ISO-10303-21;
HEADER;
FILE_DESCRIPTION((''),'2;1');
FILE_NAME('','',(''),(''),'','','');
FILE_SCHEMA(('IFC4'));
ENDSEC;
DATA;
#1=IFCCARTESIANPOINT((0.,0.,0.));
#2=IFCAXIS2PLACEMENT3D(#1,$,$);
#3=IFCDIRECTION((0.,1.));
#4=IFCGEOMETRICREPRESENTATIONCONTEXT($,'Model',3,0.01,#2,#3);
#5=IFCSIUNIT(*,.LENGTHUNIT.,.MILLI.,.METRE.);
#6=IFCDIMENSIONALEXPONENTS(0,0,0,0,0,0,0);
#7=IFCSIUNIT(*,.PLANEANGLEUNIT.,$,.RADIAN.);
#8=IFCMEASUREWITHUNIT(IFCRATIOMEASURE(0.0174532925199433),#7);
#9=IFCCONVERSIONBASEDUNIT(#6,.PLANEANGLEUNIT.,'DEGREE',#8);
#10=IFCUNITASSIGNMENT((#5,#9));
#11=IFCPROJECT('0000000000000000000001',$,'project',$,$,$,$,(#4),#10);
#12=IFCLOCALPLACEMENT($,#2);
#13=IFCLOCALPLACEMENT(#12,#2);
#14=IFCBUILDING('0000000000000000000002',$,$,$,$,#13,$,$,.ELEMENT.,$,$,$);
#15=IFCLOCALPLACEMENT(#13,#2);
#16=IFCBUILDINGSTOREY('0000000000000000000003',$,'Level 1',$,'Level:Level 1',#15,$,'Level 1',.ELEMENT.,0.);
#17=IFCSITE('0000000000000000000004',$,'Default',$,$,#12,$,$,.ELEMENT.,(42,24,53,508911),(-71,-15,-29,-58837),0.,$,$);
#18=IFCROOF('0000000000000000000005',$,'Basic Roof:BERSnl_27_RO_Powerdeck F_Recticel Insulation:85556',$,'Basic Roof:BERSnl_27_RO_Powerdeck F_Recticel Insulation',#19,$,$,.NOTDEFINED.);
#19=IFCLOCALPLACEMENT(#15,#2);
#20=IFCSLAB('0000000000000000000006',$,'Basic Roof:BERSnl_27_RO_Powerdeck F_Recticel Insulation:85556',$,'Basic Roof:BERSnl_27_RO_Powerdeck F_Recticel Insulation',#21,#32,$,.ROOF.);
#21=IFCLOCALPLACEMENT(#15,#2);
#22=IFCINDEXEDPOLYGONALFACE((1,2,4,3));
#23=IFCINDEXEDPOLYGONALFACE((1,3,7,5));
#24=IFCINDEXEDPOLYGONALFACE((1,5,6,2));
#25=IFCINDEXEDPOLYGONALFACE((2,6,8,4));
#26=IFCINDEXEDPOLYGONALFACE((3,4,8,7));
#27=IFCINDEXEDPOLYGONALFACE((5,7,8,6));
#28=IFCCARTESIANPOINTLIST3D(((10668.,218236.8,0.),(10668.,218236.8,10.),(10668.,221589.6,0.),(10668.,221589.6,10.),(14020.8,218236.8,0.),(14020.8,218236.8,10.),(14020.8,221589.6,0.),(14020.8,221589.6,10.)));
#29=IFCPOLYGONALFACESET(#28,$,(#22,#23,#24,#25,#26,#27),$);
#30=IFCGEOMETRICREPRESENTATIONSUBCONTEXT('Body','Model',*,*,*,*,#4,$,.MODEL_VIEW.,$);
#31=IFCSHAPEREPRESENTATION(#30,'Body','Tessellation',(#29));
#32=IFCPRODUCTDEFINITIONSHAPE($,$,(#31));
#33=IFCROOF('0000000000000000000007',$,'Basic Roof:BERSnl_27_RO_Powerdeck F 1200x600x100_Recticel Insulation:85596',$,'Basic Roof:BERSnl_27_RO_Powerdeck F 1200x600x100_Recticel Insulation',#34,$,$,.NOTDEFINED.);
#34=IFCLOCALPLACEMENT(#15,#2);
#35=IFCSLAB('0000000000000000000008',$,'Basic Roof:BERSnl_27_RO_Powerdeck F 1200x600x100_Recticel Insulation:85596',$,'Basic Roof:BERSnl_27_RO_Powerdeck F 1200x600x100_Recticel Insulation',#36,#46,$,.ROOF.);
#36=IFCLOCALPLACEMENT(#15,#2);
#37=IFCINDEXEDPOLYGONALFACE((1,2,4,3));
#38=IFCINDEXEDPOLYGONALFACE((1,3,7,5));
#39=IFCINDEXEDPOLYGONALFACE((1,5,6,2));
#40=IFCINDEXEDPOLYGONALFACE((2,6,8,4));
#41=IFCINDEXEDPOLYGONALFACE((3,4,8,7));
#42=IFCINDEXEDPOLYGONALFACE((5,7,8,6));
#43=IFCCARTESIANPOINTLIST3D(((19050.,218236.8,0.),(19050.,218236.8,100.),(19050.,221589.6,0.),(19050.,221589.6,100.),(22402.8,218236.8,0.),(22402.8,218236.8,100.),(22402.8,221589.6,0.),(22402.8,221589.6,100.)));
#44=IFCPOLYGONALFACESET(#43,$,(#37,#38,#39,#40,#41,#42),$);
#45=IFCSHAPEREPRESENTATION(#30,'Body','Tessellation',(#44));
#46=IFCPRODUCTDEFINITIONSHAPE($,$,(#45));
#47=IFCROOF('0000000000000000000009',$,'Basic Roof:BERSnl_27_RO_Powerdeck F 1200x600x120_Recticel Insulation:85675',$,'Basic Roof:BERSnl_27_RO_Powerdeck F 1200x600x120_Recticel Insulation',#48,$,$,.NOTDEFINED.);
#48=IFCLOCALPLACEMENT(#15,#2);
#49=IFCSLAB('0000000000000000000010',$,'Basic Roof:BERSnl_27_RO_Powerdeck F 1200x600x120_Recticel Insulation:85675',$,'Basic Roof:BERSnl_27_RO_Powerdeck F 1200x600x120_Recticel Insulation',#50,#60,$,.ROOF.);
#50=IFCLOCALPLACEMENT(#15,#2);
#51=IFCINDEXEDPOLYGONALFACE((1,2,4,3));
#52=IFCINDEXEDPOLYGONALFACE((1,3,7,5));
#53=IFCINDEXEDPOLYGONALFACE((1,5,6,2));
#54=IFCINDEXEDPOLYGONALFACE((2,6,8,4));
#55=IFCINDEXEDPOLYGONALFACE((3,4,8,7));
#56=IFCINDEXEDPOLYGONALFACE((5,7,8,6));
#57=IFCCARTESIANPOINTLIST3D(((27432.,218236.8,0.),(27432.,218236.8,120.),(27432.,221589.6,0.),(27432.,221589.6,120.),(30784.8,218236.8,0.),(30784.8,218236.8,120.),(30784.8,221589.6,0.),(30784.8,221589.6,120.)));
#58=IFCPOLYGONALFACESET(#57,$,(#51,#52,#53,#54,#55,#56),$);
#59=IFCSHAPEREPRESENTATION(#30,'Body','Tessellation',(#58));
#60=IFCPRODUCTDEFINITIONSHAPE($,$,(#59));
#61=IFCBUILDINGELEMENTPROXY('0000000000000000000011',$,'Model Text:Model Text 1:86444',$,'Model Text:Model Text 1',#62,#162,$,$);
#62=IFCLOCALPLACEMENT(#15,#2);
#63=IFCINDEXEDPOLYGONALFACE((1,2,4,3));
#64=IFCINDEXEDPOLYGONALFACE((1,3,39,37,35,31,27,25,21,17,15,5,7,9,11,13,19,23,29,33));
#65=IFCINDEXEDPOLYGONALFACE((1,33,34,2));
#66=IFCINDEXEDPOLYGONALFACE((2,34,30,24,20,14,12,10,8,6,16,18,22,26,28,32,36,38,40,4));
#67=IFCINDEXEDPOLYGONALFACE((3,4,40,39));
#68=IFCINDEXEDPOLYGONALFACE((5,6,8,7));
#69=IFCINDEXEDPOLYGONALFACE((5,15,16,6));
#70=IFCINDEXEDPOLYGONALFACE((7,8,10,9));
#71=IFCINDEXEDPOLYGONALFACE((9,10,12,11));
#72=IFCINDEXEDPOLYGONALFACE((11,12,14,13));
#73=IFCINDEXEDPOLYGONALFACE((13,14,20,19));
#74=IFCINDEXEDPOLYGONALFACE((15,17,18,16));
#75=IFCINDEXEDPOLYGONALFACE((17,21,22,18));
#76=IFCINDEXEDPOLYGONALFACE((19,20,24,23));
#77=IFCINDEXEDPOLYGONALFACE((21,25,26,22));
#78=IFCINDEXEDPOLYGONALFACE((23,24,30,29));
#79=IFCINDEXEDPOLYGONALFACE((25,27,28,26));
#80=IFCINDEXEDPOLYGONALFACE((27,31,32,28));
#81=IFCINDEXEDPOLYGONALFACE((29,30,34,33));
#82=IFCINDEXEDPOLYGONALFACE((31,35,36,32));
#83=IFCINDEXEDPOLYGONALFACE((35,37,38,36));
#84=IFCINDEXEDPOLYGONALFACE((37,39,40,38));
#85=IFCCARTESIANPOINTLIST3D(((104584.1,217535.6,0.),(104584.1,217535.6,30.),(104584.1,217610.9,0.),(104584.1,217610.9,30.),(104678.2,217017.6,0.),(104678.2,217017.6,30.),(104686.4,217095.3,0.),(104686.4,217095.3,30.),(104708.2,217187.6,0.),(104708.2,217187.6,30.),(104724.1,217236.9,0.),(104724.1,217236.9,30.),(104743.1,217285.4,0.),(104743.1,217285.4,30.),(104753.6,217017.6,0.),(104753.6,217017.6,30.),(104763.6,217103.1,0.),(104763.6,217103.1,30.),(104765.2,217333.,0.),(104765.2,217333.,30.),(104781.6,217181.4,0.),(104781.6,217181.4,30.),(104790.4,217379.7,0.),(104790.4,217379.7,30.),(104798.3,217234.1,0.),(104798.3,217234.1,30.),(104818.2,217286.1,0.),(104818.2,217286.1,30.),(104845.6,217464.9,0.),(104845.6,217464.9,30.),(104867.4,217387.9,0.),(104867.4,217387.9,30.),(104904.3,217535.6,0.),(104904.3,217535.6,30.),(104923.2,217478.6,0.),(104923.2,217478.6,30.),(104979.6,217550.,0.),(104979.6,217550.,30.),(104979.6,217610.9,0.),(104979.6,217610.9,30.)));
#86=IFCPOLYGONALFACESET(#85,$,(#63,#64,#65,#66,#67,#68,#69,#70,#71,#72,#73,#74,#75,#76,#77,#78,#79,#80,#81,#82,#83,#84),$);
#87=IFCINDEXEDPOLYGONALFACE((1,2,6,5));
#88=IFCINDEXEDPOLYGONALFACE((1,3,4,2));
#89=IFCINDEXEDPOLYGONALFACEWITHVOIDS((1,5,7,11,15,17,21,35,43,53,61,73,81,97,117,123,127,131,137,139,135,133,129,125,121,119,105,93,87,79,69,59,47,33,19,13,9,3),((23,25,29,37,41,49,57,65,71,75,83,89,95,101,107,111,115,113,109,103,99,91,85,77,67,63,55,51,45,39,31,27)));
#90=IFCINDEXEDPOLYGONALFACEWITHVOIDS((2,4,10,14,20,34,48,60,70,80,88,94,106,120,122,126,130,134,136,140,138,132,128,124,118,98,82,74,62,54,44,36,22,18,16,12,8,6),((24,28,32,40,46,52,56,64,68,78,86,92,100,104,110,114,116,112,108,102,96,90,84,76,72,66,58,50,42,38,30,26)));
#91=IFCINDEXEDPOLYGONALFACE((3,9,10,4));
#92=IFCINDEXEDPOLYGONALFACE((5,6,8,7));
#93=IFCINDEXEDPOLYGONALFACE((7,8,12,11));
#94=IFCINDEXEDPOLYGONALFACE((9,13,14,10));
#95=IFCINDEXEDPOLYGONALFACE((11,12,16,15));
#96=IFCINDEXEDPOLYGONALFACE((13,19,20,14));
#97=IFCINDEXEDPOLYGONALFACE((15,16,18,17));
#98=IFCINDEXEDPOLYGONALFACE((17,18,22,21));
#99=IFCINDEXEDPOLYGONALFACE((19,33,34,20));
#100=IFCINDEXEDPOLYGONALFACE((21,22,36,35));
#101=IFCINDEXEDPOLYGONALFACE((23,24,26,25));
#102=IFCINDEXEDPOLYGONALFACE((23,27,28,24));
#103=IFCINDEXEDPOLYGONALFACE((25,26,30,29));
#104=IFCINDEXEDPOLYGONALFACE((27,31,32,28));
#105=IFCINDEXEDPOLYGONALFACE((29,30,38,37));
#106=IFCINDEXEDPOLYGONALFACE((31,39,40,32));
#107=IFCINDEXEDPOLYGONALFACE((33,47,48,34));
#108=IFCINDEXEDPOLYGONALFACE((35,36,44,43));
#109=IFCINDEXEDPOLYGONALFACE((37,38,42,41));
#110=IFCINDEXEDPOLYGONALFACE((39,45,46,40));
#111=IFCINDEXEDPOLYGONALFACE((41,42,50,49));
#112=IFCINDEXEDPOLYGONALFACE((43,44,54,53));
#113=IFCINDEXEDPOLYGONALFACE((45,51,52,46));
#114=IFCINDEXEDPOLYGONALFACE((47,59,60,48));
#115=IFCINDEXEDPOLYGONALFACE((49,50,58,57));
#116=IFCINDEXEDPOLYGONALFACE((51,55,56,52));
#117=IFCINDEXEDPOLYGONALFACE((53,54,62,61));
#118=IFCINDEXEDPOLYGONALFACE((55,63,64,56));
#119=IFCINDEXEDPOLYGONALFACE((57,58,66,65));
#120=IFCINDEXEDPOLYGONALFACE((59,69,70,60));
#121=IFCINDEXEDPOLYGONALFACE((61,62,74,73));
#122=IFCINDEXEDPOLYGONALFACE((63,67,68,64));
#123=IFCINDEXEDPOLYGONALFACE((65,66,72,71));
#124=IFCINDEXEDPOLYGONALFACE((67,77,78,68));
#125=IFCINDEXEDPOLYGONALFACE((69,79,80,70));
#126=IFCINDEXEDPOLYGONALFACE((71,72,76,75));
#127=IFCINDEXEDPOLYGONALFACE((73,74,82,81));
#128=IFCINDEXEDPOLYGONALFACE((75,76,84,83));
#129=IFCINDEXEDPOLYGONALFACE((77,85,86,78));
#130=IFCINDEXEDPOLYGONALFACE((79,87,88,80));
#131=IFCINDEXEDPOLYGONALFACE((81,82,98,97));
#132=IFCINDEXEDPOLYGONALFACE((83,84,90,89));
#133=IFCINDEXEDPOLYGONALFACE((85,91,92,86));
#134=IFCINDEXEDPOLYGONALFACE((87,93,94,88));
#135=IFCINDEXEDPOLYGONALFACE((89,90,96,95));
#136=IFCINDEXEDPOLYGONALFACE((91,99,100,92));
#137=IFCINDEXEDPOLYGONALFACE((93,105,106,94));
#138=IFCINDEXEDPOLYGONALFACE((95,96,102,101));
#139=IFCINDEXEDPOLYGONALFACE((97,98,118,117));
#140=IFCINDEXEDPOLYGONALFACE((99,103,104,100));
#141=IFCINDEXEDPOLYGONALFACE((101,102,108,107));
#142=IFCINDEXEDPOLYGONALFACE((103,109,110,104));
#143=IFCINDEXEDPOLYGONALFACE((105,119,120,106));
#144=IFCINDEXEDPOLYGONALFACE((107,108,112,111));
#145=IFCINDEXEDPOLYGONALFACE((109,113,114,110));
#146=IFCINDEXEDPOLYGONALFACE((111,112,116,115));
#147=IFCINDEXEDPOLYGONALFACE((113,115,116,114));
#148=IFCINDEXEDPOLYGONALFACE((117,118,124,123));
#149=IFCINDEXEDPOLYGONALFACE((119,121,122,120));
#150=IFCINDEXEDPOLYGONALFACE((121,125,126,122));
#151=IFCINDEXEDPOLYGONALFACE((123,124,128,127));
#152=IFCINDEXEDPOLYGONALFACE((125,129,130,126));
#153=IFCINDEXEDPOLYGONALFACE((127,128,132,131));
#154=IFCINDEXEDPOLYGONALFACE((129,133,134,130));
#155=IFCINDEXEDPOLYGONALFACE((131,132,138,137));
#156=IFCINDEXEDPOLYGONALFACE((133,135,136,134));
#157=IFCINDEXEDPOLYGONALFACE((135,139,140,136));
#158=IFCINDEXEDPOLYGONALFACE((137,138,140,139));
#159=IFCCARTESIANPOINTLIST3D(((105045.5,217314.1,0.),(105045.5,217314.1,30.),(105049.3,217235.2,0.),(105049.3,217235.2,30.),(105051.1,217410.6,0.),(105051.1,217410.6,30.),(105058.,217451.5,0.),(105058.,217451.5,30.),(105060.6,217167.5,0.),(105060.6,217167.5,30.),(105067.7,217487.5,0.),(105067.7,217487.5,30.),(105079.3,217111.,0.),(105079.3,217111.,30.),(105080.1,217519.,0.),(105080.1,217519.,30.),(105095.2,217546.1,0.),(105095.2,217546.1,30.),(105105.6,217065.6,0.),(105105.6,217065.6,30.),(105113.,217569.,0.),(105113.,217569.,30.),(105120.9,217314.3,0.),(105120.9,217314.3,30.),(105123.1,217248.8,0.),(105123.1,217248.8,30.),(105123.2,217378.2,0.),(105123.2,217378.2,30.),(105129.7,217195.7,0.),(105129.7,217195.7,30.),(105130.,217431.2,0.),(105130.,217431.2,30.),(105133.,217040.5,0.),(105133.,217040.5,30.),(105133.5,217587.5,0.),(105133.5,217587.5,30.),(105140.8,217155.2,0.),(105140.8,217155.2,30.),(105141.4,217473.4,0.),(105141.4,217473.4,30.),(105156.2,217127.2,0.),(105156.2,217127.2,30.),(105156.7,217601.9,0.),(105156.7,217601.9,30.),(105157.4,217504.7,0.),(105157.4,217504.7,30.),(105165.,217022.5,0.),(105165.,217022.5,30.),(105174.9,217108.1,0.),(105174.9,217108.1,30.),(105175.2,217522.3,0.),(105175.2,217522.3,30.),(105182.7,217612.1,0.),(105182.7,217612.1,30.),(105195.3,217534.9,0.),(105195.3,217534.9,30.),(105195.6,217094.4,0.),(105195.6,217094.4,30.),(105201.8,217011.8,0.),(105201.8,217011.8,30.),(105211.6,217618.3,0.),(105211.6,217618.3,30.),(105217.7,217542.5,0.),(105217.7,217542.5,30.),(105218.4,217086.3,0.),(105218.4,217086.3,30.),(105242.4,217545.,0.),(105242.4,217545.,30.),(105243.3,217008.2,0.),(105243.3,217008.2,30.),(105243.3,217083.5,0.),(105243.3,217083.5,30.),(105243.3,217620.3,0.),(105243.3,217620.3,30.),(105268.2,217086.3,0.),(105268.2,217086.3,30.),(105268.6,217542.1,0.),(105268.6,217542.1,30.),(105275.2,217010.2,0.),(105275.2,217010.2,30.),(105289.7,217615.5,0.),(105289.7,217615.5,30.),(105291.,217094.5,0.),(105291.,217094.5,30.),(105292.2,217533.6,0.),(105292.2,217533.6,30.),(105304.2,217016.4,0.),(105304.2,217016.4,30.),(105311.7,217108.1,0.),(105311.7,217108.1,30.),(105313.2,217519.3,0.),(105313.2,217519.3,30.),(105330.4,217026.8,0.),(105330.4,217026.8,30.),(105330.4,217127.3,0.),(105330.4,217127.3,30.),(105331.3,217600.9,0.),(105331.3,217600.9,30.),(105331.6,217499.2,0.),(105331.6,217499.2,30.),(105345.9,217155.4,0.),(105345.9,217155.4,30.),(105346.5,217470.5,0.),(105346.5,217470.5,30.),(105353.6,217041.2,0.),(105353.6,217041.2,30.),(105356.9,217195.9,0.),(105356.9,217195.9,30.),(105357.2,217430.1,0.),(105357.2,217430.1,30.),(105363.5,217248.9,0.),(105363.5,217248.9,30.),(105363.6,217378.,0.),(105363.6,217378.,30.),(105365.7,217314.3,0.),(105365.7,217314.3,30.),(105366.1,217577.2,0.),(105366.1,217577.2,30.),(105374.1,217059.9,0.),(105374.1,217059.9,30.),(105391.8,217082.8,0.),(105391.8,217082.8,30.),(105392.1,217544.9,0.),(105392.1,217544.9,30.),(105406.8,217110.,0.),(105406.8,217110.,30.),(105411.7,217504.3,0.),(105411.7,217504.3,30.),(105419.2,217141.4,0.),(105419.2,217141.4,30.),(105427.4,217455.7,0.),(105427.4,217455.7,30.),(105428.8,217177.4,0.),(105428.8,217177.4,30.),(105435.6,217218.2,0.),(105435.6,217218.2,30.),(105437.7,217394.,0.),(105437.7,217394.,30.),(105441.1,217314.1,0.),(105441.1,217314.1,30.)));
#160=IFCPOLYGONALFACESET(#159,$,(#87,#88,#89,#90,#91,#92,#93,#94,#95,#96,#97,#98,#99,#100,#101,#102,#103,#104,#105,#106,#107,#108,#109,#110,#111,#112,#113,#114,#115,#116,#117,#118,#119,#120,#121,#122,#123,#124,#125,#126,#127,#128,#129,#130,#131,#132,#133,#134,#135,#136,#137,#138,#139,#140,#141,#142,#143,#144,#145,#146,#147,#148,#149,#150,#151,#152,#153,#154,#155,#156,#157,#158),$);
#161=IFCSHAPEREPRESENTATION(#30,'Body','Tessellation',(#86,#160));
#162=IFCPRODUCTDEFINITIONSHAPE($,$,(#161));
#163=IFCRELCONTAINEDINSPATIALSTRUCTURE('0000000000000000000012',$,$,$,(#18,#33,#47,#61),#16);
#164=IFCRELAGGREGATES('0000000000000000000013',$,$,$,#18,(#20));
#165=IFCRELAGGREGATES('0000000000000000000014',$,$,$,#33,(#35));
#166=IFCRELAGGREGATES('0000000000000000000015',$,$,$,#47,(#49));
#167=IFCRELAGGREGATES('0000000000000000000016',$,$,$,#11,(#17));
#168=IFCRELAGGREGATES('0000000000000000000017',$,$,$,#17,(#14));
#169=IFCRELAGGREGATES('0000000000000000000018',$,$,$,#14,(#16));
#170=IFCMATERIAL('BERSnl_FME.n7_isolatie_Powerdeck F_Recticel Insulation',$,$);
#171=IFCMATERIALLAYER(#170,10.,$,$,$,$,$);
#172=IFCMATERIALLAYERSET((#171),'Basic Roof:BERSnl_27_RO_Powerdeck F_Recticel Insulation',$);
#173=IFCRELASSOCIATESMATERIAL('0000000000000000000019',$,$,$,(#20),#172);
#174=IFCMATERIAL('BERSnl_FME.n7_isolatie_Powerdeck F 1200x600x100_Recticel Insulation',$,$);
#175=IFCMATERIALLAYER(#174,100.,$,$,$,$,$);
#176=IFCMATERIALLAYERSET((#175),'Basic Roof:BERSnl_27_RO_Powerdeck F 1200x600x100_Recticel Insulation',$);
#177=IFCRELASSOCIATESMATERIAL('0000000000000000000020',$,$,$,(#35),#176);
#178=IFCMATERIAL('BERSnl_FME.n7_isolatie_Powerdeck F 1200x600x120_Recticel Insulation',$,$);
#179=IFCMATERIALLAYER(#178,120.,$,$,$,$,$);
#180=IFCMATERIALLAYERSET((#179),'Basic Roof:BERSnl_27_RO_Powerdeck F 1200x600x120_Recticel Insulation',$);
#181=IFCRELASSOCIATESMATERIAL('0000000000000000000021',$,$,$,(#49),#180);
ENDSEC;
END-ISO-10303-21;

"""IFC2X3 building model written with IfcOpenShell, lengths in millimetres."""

from ifc_helpers import new_model, entity, si_unit, converted_unit, direction, frame, frame_2d, origin, place, context, subcontext, project, spatial, polyline, rectangle, outline, extrude, material, layer, layer_set, element, aggregate, save


model = new_model("IFC2X3")

# Units and contexts
model_context = context("Model", 3, precision=0.01, world=origin(), true_north=direction((0.0, 1.0)))
body_context = subcontext(model_context, "Body", "Model", "MODEL_VIEW")
ifc_project = project(units=[si_unit("LENGTHUNIT", "METRE", prefix="MILLI"), converted_unit("PLANEANGLEUNIT", "DEGREE", entity("IfcRatioMeasure", 0.0174532925199433), si_unit("PLANEANGLEUNIT", "RADIAN"), dimensions=[0, 0, 0, 0, 0, 0, 0])], contexts=[model_context])

# Site, building, storey
site_placement = place(None, origin())
site = spatial("IfcSite", under=ifc_project, at=site_placement, Name="Default", CompositionType="ELEMENT", RefLatitude=(42, 24, 53, 508911), RefLongitude=(-71, -15, -29, -58837), RefElevation=0.0)
building_placement = place(site_placement, origin())
building = spatial("IfcBuilding", under=site, at=building_placement, CompositionType="ELEMENT")
storey_placement = place(building_placement, origin())
storey = spatial("IfcBuildingStorey", under=building, at=storey_placement, Name="Level 1", ObjectType="Level:Level 1", LongName="Level 1", CompositionType="ELEMENT", Elevation=0.0)

# Roofs, slabs
roof_1_placement = place(storey_placement, frame((10668.0, 218236.8, 0.0)))
roof_1 = element("IfcRoof", 1, at=roof_1_placement, inside=storey, Name="Basic Roof:BERSnl_27_RO_Powerdeck F_Recticel Insulation:85556", ObjectType="Basic Roof:BERSnl_27_RO_Powerdeck F_Recticel Insulation", ShapeType="NOTDEFINED")
ifc_material_1 = material(Name="BERSnl_FME.n7_isolatie_Powerdeck F_Recticel Insulation")
ifc_layer_1 = layer(ifc_material_1, 10.0)
ifc_layer_set_1 = layer_set([ifc_layer_1], Name="Basic Roof:BERSnl_27_RO_Powerdeck F_Recticel Insulation")
slab_1_placement = place(roof_1_placement, origin())
slab_1 = element("IfcSlab", 2, at=slab_1_placement, material=ifc_layer_set_1, Name="Basic Roof:BERSnl_27_RO_Powerdeck F_Recticel Insulation:85556", ObjectType="Basic Roof:BERSnl_27_RO_Powerdeck F_Recticel Insulation", PredefinedType="ROOF", context=body_context, shape_type="SweptSolid", body=[
    extrude(rectangle(XDim=3352.8, YDim=3352.8, at=frame_2d((0.0, 0.0), x_axis=(-1.0, 0.0))), frame((1676.4, 1676.4, 0.0)), (0.0, 0.0, 1.0), 10.0),
])
aggregate(roof_1, [slab_1])
roof_2_placement = place(storey_placement, frame((19050.0, 218236.8, 0.0)))
roof_2 = element("IfcRoof", 3, at=roof_2_placement, inside=storey, Name="Basic Roof:BERSnl_27_RO_Powerdeck F 1200x600x100_Recticel Insulation:85596", ObjectType="Basic Roof:BERSnl_27_RO_Powerdeck F 1200x600x100_Recticel Insulation", ShapeType="NOTDEFINED")
ifc_material_2 = material(Name="BERSnl_FME.n7_isolatie_Powerdeck F 1200x600x100_Recticel Insulation")
ifc_layer_2 = layer(ifc_material_2, 100.0)
ifc_layer_set_2 = layer_set([ifc_layer_2], Name="Basic Roof:BERSnl_27_RO_Powerdeck F 1200x600x100_Recticel Insulation")
slab_2_placement = place(roof_2_placement, origin())
slab_2 = element("IfcSlab", 4, at=slab_2_placement, material=ifc_layer_set_2, Name="Basic Roof:BERSnl_27_RO_Powerdeck F 1200x600x100_Recticel Insulation:85596", ObjectType="Basic Roof:BERSnl_27_RO_Powerdeck F 1200x600x100_Recticel Insulation", PredefinedType="ROOF", context=body_context, shape_type="SweptSolid", body=[
    extrude(rectangle(XDim=3352.8, YDim=3352.8, at=frame_2d((0.0, 0.0), x_axis=(-1.0, 0.0))), frame((1676.4, 1676.4, 0.0)), (0.0, 0.0, 1.0), 100.0),
])
aggregate(roof_2, [slab_2])
roof_3_placement = place(storey_placement, frame((27432.0, 218236.8, 0.0)))
roof_3 = element("IfcRoof", 5, at=roof_3_placement, inside=storey, Name="Basic Roof:BERSnl_27_RO_Powerdeck F 1200x600x120_Recticel Insulation:85675", ObjectType="Basic Roof:BERSnl_27_RO_Powerdeck F 1200x600x120_Recticel Insulation", ShapeType="NOTDEFINED")
ifc_material_3 = material(Name="BERSnl_FME.n7_isolatie_Powerdeck F 1200x600x120_Recticel Insulation")
ifc_layer_3 = layer(ifc_material_3, 120.0)
ifc_layer_set_3 = layer_set([ifc_layer_3], Name="Basic Roof:BERSnl_27_RO_Powerdeck F 1200x600x120_Recticel Insulation")
slab_3_placement = place(roof_3_placement, origin())
slab_3 = element("IfcSlab", 6, at=slab_3_placement, material=ifc_layer_set_3, Name="Basic Roof:BERSnl_27_RO_Powerdeck F 1200x600x120_Recticel Insulation:85675", ObjectType="Basic Roof:BERSnl_27_RO_Powerdeck F 1200x600x120_Recticel Insulation", PredefinedType="ROOF", context=body_context, shape_type="SweptSolid", body=[
    extrude(rectangle(XDim=3352.8, YDim=3352.8, at=frame_2d((0.0, 0.0), x_axis=(-1.0, 0.0))), frame((1676.4, 1676.4, 0.0)), (0.0, 0.0, 1.0), 120.0),
])
aggregate(roof_3, [slab_3])

# Building element proxy
proxy_1_placement = place(storey_placement, origin())
element("IfcBuildingElementProxy", 7, at=proxy_1_placement, inside=storey, Name="Model Text:Model Text 1:86444", ObjectType="Model Text:Model Text 1", context=body_context, shape_type="SweptSolid", body=[
    extrude(outline(polyline([(-199.9, -209.0), (-199.9, -284.3), (195.7, -284.3), (195.7, -223.4), (139.3, -152.0), (83.5, -61.3), (34.2, 40.5), (14.4, 92.5), (-2.4, 145.2), (-20.3, 223.5), (-30.3, 309.0), (-105.7, 309.0), (-97.5, 231.3), (-75.7, 139.0), (-59.9, 89.7), (-40.9, 41.2), (-18.8, -6.4), (6.4, -53.1), (61.7, -138.3), (120.3, -209.0), (-199.9, -209.0)])), frame((104783.9, 217326.6, 0.0), z_axis=(0.0, 0.0, -1.0), x_axis=(1.0, 0.0, 0.0)), (0.0, 0.0, -1.0), 30.0),
    extrude(outline(polyline([(-10.6, -198.7), (68.3, -198.7), (136.5, -190.7), (193.9, -174.7), (240.5, -150.6), (266.9, -124.4), (286.3, -93.2), (298.8, -57.0), (304.3, -15.7), (303.8, 16.2), (299.0, 45.5), (289.9, 72.1), (276.6, 96.0), (258.9, 117.3), (236.9, 136.2), (210.4, 152.5), (179.6, 166.3), (144.1, 177.6), (103.7, 186.3), (8.2, 196.4), (-71.8, 196.7), (-134.0, 189.4), (-183.3, 176.1), (-224.7, 158.4), (-258.2, 133.9), (-283.5, 100.3), (-300.1, 59.5), (-307.1, 13.4), (-306.6, -18.4), (-301.8, -47.5), (-292.8, -74.0), (-279.6, -97.9), (-262.0, -119.2), (-240.0, -138.1), (-213.6, -154.5), (-182.8, -168.4), (-147.3, -179.8), (-106.7, -188.6), (-10.6, -198.7)]), holes=[polyline([(-7.2, -123.5), (-71.0, -118.2), (-123.6, -108.8), (-165.2, -95.4), (-195.7, -78.0), (-212.4, -59.4), (-224.1, -38.7), (-230.6, -15.9), (-231.9, 8.9), (-227.8, 35.0), (-218.1, 58.1), (-202.8, 78.4), (-182.0, 95.8), (-152.6, 109.4), (-111.7, 118.1), (-59.4, 122.0), (4.4, 121.1), (69.6, 115.8), (122.2, 106.7), (162.2, 93.7), (189.5, 77.0), (207.7, 57.4), (220.4, 36.0), (227.5, 12.8), (229.1, -12.1), (225.2, -36.8), (215.9, -59.2), (201.3, -79.3), (181.4, -97.1), (152.6, -111.2), (111.6, -120.3), (58.3, -124.4), (-7.2, -123.5)])]), frame((105244.6, 217312.9, 0.0), z_axis=(0.0, 0.0, 1.0), x_axis=(0.047515, -0.998871, 0.0)), (0.0, 0.0, 1.0), 30.0),
])

save(model, "model.ifc")
